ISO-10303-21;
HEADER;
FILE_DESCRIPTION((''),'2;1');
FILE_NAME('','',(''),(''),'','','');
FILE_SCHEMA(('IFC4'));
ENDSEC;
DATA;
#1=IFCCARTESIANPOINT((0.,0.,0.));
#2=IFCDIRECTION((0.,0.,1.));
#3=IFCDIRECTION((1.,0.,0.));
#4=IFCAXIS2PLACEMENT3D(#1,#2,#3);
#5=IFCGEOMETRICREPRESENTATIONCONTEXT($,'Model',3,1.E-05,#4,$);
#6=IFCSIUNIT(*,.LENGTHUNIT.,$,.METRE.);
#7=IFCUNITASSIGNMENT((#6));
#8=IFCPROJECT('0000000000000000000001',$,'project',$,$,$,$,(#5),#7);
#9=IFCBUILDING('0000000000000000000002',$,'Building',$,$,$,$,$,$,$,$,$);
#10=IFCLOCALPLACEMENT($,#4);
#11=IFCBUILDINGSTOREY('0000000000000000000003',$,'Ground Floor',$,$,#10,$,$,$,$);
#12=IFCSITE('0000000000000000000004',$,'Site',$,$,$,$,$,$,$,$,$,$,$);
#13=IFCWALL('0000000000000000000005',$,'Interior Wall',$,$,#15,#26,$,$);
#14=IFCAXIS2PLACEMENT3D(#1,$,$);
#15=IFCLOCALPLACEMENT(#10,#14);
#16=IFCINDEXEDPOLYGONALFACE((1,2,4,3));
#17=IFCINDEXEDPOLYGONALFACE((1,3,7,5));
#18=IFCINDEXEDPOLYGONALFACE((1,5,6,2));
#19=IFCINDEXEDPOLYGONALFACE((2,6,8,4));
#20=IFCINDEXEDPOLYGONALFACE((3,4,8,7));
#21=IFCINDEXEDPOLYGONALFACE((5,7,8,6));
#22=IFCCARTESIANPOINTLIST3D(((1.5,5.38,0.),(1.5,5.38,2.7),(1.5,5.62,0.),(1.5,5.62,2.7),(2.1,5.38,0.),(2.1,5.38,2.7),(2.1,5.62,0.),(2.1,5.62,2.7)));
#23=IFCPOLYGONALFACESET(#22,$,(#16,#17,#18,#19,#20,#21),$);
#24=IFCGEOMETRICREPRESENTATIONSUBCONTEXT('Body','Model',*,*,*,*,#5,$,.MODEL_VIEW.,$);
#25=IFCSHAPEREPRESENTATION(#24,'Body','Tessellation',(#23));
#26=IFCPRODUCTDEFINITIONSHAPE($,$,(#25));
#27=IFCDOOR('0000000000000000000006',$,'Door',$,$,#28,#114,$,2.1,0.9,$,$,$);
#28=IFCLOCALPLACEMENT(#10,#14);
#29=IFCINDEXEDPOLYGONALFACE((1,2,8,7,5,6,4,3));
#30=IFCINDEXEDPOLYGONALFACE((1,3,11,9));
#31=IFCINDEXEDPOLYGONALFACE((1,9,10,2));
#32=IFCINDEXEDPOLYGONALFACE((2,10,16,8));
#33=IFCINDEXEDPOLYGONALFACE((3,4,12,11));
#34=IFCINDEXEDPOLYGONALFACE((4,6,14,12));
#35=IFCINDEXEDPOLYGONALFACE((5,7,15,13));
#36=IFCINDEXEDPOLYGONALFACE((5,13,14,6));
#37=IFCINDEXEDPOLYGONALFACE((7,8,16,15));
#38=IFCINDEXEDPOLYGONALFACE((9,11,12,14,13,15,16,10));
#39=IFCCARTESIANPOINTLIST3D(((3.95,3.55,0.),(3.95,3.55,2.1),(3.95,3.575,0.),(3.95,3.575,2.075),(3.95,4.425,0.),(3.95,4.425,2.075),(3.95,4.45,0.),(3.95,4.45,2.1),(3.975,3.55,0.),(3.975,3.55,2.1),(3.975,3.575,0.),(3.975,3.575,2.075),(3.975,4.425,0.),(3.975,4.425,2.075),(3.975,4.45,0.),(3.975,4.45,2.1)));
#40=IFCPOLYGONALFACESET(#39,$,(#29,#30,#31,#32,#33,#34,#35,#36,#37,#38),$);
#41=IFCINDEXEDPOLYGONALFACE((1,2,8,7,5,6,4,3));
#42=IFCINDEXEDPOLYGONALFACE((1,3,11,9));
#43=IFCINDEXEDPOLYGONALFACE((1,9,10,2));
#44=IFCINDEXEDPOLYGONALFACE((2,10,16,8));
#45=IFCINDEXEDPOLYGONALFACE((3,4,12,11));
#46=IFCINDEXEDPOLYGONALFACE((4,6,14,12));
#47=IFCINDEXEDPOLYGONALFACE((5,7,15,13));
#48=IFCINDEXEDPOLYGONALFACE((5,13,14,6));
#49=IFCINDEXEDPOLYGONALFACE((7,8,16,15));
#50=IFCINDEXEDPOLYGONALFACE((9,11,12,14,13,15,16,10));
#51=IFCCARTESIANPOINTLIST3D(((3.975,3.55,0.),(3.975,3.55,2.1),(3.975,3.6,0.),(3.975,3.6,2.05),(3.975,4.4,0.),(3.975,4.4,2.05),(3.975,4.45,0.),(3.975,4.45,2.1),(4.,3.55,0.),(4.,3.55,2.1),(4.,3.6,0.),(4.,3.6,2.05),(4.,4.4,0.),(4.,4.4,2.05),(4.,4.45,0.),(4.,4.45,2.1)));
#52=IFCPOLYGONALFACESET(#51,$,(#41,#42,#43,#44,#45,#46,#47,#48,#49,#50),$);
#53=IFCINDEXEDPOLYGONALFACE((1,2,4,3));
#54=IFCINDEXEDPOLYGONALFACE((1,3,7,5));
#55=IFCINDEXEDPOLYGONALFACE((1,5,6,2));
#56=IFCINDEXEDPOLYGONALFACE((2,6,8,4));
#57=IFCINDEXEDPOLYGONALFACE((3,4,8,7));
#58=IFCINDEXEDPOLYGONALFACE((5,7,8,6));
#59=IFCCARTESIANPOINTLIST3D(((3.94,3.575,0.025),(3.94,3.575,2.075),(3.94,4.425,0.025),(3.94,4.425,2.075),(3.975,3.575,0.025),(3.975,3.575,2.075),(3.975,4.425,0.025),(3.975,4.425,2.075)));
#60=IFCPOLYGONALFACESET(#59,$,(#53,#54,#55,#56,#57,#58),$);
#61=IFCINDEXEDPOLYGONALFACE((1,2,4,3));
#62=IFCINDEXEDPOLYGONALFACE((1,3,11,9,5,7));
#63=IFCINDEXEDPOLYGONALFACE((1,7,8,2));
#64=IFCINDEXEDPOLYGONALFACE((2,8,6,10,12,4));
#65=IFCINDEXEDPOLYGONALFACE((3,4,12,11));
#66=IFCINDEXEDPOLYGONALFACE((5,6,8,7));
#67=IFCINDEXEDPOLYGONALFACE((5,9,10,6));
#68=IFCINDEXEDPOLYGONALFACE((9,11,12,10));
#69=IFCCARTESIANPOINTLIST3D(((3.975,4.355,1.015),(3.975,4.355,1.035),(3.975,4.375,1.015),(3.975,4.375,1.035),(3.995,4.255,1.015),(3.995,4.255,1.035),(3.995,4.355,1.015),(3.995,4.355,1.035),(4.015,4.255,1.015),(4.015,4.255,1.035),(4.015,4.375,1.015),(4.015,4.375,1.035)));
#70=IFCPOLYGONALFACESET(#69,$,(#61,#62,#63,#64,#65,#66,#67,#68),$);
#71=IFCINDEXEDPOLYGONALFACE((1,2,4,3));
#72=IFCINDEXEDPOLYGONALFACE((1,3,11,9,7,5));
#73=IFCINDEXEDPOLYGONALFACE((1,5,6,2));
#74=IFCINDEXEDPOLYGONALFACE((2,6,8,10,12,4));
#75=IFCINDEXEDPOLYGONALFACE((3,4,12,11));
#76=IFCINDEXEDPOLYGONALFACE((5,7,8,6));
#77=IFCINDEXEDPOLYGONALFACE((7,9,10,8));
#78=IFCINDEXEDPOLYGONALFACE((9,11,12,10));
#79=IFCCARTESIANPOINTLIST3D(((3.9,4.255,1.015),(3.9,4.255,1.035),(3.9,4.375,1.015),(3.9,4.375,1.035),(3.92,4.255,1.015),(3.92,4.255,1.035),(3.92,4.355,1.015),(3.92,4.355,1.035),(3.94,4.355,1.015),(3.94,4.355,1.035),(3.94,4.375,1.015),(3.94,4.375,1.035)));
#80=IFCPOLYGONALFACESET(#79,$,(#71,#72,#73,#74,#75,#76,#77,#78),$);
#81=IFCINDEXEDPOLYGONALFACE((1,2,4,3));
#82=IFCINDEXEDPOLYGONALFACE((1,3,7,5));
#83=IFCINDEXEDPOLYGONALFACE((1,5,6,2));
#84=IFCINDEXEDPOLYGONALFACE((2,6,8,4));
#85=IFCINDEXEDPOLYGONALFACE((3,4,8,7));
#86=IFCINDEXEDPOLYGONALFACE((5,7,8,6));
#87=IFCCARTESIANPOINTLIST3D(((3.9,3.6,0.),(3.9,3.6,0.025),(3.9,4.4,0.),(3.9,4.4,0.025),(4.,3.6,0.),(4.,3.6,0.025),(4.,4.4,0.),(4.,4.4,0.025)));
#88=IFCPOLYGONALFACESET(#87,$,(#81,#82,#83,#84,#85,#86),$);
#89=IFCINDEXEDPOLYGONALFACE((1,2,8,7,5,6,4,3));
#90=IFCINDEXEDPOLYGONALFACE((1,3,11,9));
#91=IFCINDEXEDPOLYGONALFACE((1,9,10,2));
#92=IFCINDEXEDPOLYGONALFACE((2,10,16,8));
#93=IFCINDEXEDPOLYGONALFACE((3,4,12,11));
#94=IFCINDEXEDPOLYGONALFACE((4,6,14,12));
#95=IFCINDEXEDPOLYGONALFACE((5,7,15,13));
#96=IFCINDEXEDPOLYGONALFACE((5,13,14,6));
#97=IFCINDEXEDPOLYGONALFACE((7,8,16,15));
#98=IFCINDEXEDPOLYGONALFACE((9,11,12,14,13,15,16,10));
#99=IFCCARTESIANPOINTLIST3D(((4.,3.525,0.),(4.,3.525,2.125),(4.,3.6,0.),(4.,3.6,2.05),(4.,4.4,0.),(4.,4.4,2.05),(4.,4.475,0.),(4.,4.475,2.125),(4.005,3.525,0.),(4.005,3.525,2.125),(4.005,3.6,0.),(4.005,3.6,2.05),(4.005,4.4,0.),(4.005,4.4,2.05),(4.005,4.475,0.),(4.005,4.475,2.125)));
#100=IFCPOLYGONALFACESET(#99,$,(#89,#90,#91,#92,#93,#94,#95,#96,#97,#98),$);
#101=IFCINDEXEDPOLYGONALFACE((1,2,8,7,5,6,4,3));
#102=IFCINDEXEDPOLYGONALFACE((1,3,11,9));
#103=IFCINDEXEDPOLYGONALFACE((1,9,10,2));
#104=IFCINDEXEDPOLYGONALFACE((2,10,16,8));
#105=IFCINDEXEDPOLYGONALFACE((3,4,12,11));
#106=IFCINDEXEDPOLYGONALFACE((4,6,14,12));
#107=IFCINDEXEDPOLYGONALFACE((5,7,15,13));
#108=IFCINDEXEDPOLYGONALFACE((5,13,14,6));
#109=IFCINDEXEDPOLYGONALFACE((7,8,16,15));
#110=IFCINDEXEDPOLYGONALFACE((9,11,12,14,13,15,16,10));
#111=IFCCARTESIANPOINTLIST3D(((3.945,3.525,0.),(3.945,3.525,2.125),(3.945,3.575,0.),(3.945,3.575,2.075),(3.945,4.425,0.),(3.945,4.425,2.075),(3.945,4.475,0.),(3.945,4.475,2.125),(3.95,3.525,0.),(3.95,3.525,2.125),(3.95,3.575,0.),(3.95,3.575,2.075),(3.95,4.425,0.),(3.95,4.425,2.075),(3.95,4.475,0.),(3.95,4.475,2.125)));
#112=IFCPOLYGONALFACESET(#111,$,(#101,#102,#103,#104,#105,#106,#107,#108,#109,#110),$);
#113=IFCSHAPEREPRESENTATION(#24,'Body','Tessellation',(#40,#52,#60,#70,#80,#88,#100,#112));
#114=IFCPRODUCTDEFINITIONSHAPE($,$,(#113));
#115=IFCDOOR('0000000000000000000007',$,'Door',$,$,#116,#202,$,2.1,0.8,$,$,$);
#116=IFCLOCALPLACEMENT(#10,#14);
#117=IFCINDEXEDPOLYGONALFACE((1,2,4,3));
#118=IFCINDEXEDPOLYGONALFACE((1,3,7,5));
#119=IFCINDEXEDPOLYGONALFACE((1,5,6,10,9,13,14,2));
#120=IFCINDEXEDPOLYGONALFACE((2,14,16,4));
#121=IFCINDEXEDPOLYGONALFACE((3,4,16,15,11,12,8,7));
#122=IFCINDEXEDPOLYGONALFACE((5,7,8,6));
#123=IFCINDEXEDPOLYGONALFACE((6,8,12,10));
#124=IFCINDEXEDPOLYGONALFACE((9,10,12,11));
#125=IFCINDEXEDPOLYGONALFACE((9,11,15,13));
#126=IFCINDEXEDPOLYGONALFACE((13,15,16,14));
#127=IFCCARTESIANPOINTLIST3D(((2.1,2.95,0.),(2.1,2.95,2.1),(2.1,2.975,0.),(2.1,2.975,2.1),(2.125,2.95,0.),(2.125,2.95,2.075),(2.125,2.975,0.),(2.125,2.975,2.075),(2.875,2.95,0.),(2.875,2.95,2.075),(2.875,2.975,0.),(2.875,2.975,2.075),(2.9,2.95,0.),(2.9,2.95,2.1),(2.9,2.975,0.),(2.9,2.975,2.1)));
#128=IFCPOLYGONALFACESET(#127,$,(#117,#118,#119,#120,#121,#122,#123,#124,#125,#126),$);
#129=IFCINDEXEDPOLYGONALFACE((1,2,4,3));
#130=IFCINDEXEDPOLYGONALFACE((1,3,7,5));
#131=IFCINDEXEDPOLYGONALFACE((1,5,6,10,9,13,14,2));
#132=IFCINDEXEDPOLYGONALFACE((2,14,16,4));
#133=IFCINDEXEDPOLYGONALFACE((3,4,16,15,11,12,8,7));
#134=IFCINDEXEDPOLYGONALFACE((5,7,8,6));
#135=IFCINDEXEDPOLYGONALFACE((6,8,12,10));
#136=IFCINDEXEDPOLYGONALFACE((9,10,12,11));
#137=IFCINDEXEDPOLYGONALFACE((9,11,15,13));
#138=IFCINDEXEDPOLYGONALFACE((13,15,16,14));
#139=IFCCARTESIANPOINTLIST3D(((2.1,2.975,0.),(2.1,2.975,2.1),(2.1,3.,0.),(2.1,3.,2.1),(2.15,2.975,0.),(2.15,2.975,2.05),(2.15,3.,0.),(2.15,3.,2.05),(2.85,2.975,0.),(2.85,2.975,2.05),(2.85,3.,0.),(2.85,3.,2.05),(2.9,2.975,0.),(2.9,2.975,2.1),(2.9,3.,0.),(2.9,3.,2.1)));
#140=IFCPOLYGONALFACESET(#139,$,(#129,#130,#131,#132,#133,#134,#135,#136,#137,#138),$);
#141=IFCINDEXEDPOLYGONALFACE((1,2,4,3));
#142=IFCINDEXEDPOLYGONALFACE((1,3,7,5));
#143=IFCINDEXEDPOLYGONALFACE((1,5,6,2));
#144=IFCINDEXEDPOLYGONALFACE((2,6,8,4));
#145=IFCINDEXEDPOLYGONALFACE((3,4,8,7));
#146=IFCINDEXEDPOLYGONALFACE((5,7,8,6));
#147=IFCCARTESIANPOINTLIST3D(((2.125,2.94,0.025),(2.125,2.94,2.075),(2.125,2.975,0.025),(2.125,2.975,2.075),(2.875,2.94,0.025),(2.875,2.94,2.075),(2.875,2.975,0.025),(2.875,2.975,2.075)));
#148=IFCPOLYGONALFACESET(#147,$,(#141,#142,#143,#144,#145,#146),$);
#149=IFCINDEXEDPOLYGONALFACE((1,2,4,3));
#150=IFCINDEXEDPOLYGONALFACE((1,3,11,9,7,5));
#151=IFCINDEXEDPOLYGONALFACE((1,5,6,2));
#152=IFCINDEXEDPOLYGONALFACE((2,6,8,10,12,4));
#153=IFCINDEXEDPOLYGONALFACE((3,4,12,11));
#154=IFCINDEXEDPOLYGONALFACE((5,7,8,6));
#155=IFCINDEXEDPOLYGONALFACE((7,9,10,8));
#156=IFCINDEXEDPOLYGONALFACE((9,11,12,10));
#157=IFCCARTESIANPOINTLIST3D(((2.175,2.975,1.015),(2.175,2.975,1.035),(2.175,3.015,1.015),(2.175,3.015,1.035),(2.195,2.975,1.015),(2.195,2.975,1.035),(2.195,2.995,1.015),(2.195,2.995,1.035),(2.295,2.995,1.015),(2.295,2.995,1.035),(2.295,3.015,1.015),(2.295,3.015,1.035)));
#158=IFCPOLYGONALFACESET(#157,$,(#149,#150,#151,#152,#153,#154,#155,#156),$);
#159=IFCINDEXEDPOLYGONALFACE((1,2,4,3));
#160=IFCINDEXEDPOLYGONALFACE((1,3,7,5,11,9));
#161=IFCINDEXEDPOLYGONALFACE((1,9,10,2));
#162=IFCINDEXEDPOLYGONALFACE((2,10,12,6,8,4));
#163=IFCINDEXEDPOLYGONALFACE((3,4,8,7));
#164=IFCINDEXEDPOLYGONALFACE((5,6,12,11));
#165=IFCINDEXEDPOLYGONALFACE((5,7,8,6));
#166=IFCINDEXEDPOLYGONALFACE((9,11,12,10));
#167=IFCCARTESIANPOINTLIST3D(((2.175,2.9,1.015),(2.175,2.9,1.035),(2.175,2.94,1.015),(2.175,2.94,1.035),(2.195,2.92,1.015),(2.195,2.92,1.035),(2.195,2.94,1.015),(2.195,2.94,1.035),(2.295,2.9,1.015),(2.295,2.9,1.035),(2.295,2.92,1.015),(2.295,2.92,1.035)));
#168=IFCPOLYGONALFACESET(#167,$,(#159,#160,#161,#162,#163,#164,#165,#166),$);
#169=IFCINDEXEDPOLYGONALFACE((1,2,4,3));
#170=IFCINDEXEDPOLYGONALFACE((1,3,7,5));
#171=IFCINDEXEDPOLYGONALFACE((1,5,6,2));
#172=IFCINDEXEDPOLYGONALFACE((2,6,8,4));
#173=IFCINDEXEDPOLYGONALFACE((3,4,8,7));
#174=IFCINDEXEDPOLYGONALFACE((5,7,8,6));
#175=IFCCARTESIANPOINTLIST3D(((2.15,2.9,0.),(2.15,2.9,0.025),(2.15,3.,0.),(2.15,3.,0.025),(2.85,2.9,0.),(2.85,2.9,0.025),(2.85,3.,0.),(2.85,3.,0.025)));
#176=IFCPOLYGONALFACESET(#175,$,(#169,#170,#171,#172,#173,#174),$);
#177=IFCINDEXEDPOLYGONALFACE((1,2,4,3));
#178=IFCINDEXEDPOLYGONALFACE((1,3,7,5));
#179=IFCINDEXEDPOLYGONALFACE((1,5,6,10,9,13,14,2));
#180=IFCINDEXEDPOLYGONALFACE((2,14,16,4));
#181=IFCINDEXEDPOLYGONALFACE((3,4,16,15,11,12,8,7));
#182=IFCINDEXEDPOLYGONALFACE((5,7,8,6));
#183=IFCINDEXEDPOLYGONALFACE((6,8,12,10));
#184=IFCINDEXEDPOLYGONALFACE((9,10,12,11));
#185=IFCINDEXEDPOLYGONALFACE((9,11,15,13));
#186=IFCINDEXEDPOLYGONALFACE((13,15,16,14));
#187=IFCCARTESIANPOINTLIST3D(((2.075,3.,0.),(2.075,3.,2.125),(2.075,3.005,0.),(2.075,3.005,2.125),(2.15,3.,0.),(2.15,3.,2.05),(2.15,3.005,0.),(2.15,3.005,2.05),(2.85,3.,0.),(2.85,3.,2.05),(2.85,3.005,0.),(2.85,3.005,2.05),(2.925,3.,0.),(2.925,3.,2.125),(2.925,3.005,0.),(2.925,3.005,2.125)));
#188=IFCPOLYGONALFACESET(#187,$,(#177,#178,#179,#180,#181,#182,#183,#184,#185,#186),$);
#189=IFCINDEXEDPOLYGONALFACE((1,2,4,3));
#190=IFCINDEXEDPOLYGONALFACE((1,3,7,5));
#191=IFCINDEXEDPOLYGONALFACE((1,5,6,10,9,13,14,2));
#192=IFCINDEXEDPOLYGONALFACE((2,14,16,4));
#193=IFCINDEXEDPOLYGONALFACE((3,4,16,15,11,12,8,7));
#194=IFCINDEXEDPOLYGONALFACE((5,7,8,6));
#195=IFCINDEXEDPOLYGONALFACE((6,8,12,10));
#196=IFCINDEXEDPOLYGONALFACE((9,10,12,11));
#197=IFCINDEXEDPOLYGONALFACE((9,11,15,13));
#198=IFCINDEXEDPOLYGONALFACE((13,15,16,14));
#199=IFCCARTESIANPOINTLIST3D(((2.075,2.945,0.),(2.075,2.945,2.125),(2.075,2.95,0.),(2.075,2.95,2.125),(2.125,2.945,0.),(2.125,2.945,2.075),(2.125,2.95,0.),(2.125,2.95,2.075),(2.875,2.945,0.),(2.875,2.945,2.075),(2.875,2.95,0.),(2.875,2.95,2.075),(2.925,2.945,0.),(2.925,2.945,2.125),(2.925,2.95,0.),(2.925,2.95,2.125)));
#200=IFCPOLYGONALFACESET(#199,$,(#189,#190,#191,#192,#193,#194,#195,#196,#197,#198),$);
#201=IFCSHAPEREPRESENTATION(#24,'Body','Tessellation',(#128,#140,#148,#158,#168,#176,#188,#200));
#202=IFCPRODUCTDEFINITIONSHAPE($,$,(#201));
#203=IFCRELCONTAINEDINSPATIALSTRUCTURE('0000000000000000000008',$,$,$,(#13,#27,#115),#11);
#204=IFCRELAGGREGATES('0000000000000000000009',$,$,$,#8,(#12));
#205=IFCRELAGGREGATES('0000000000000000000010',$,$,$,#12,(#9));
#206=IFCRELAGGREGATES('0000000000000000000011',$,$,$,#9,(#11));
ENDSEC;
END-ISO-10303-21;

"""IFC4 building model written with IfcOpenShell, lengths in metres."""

from ifc_helpers import new_model, si_unit, frame, origin_with_axes, place, context, subcontext, project, spatial, line, indexed_curve, outline, extrude, element, save


model = new_model("IFC4")

# Units and contexts
model_context = context("Model", 3, precision=1e-05, world=origin_with_axes())
body_context = subcontext(model_context, "Body", "Model", "MODEL_VIEW")
ifc_project = project(units=[si_unit("LENGTHUNIT", "METRE")], contexts=[model_context])

# Site, building, storey
site = spatial("IfcSite", under=ifc_project, Name="Site")
building = spatial("IfcBuilding", under=site, Name="Building")
storey_placement = place(None, origin_with_axes())
storey = spatial("IfcBuildingStorey", under=building, at=storey_placement, Name="Ground Floor")

# Wall
wall_1_placement = place(storey_placement, frame((2.1, 5.5, 0.0), z_axis=(0.0, 0.0, 1.0), x_axis=(-1.0, 0.0, 0.0)))
element("IfcWall", 1, at=wall_1_placement, inside=storey, Name="Interior Wall", context=body_context, shape_type="SweptSolid", body=[
    extrude(outline(indexed_curve([(0.0, 0.0), (0.0, 0.24), (0.6, 0.24), (0.6, 0.0), (0.0, 0.0)], self_intersect=False)), frame((0.0, -0.12, 0.0), z_axis=(0.0, 0.0, 1.0), x_axis=(1.0, 0.0, 0.0)), (0.0, 0.0, 1.0), 2.7),
])

# Doors
door_1_placement = place(storey_placement, frame((4.0, 3.55, 0.0), z_axis=(0.0, 0.0, 1.0), x_axis=(0.0, 1.0, 0.0)))
element("IfcDoor", 2, at=door_1_placement, inside=storey, Name="Door", OverallHeight=2.1, OverallWidth=0.9, context=body_context, shape_type="SweptSolid", body=[
    extrude(outline(indexed_curve([(0.0, 0.0), (0.0, 2.1), (0.9, 2.1), (0.9, 0.0), (0.875, 0.0), (0.875, 2.075), (0.025, 2.075), (0.025, 0.0)], segments=[line(1, 2, 3, 4, 5, 6, 7, 8, 1)])), frame((0.0, 0.025, 0.0), z_axis=(0.0, -1.0, 0.0), x_axis=(1.0, 0.0, 0.0)), (0.0, 0.0, -1.0), 0.025),
    extrude(outline(indexed_curve([(0.0, 0.0), (0.0, 2.1), (0.9, 2.1), (0.9, 0.0), (0.85, 0.0), (0.85, 2.05), (0.05, 2.05), (0.05, 0.0)], segments=[line(1, 2, 3, 4, 5, 6, 7, 8, 1)])), frame((0.0, 0.0, 0.0), z_axis=(0.0, -1.0, 0.0), x_axis=(1.0, 0.0, 0.0)), (0.0, 0.0, -1.0), 0.025),
    extrude(outline(indexed_curve([(0.0, 0.0), (0.85, 0.0), (0.85, 0.035), (0.0, 0.035)], segments=[line(1, 2, 3, 4, 1)])), frame((0.025, 0.025, 0.025), z_axis=(0.0, 0.0, 1.0), x_axis=(1.0, 0.0, 0.0)), (0.0, 0.0, 1.0), 2.05),
    extrude(outline(indexed_curve([(0.0, 0.0), (0.0, -0.04), (-0.12, -0.04), (-0.12, -0.02), (-0.02, -0.02), (-0.02, 0.0)], segments=[line(1, 2, 3, 4, 5, 6, 1)])), frame((0.825, 0.025, 1.015), z_axis=(0.0, 0.0, 1.0), x_axis=(1.0, 0.0, 0.0)), (0.0, 0.0, 1.0), 0.02),
    extrude(outline(indexed_curve([(0.0, 0.0), (0.0, 0.04), (-0.12, 0.04), (-0.12, 0.02), (-0.02, 0.02), (-0.02, 0.0)], segments=[line(1, 2, 3, 4, 5, 6, 1)])), frame((0.825, 0.06, 1.015), z_axis=(0.0, 0.0, 1.0), x_axis=(1.0, 0.0, 0.0)), (0.0, 0.0, 1.0), 0.02),
    extrude(outline(indexed_curve([(0.0, 0.0), (0.8, 0.0), (0.8, 0.1), (0.0, 0.1)], segments=[line(1, 2, 3, 4, 1)])), frame((0.05, 0.0, 0.0), z_axis=(0.0, 0.0, 1.0), x_axis=(1.0, 0.0, 0.0)), (0.0, 0.0, 1.0), 0.025),
    extrude(outline(indexed_curve([(0.0, 0.0), (0.0, 2.125), (0.95, 2.125), (0.95, 0.0), (0.875, 0.0), (0.875, 2.05), (0.075, 2.05), (0.075, 0.0)], segments=[line(1, 2, 3, 4, 5, 6, 7, 8, 1)])), frame((-0.025, -0.005, 0.0), z_axis=(0.0, -1.0, 0.0), x_axis=(1.0, 0.0, 0.0)), (0.0, 0.0, -1.0), 0.005),
    extrude(outline(indexed_curve([(0.0, 0.0), (0.0, 2.125), (0.95, 2.125), (0.95, 0.0), (0.9, 0.0), (0.9, 2.075), (0.05, 2.075), (0.05, 0.0)], segments=[line(1, 2, 3, 4, 5, 6, 7, 8, 1)])), frame((-0.025, 0.05, 0.0), z_axis=(0.0, -1.0, 0.0), x_axis=(1.0, 0.0, 0.0)), (0.0, 0.0, -1.0), 0.005),
])
door_2_placement = place(storey_placement, frame((2.9, 3.0, 0.0), z_axis=(0.0, 0.0, 1.0), x_axis=(-1.0, 0.0, 0.0)))
element("IfcDoor", 3, at=door_2_placement, inside=storey, Name="Door", OverallHeight=2.1, OverallWidth=0.8, context=body_context, shape_type="SweptSolid", body=[
    extrude(outline(indexed_curve([(0.0, 0.0), (0.0, 2.1), (0.8, 2.1), (0.8, 0.0), (0.775, 0.0), (0.775, 2.075), (0.025, 2.075), (0.025, 0.0)], segments=[line(1, 2, 3, 4, 5, 6, 7, 8, 1)])), frame((0.0, 0.025, 0.0), z_axis=(0.0, -1.0, 0.0), x_axis=(1.0, 0.0, 0.0)), (0.0, 0.0, -1.0), 0.025),
    extrude(outline(indexed_curve([(0.0, 0.0), (0.0, 2.1), (0.8, 2.1), (0.8, 0.0), (0.75, 0.0), (0.75, 2.05), (0.05, 2.05), (0.05, 0.0)], segments=[line(1, 2, 3, 4, 5, 6, 7, 8, 1)])), frame((0.0, 0.0, 0.0), z_axis=(0.0, -1.0, 0.0), x_axis=(1.0, 0.0, 0.0)), (0.0, 0.0, -1.0), 0.025),
    extrude(outline(indexed_curve([(0.0, 0.0), (0.75, 0.0), (0.75, 0.035), (0.0, 0.035)], segments=[line(1, 2, 3, 4, 1)])), frame((0.025, 0.025, 0.025), z_axis=(0.0, 0.0, 1.0), x_axis=(1.0, 0.0, 0.0)), (0.0, 0.0, 1.0), 2.05),
    extrude(outline(indexed_curve([(0.0, 0.0), (0.0, -0.04), (-0.12, -0.04), (-0.12, -0.02), (-0.02, -0.02), (-0.02, 0.0)], segments=[line(1, 2, 3, 4, 5, 6, 1)])), frame((0.725, 0.025, 1.015), z_axis=(0.0, 0.0, 1.0), x_axis=(1.0, 0.0, 0.0)), (0.0, 0.0, 1.0), 0.02),
    extrude(outline(indexed_curve([(0.0, 0.0), (0.0, 0.04), (-0.12, 0.04), (-0.12, 0.02), (-0.02, 0.02), (-0.02, 0.0)], segments=[line(1, 2, 3, 4, 5, 6, 1)])), frame((0.725, 0.06, 1.015), z_axis=(0.0, 0.0, 1.0), x_axis=(1.0, 0.0, 0.0)), (0.0, 0.0, 1.0), 0.02),
    extrude(outline(indexed_curve([(0.0, 0.0), (0.7, 0.0), (0.7, 0.1), (0.0, 0.1)], segments=[line(1, 2, 3, 4, 1)])), frame((0.05, 0.0, 0.0), z_axis=(0.0, 0.0, 1.0), x_axis=(1.0, 0.0, 0.0)), (0.0, 0.0, 1.0), 0.025),
    extrude(outline(indexed_curve([(0.0, 0.0), (0.0, 2.125), (0.85, 2.125), (0.85, 0.0), (0.775, 0.0), (0.775, 2.05), (0.075, 2.05), (0.075, 0.0)], segments=[line(1, 2, 3, 4, 5, 6, 7, 8, 1)])), frame((-0.025, -0.005, 0.0), z_axis=(0.0, -1.0, 0.0), x_axis=(1.0, 0.0, 0.0)), (0.0, 0.0, -1.0), 0.005),
    extrude(outline(indexed_curve([(0.0, 0.0), (0.0, 2.125), (0.85, 2.125), (0.85, 0.0), (0.8, 0.0), (0.8, 2.075), (0.05, 2.075), (0.05, 0.0)], segments=[line(1, 2, 3, 4, 5, 6, 7, 8, 1)])), frame((-0.025, 0.05, 0.0), z_axis=(0.0, -1.0, 0.0), x_axis=(1.0, 0.0, 0.0)), (0.0, 0.0, -1.0), 0.005),
])

save(model, "model.ifc")
